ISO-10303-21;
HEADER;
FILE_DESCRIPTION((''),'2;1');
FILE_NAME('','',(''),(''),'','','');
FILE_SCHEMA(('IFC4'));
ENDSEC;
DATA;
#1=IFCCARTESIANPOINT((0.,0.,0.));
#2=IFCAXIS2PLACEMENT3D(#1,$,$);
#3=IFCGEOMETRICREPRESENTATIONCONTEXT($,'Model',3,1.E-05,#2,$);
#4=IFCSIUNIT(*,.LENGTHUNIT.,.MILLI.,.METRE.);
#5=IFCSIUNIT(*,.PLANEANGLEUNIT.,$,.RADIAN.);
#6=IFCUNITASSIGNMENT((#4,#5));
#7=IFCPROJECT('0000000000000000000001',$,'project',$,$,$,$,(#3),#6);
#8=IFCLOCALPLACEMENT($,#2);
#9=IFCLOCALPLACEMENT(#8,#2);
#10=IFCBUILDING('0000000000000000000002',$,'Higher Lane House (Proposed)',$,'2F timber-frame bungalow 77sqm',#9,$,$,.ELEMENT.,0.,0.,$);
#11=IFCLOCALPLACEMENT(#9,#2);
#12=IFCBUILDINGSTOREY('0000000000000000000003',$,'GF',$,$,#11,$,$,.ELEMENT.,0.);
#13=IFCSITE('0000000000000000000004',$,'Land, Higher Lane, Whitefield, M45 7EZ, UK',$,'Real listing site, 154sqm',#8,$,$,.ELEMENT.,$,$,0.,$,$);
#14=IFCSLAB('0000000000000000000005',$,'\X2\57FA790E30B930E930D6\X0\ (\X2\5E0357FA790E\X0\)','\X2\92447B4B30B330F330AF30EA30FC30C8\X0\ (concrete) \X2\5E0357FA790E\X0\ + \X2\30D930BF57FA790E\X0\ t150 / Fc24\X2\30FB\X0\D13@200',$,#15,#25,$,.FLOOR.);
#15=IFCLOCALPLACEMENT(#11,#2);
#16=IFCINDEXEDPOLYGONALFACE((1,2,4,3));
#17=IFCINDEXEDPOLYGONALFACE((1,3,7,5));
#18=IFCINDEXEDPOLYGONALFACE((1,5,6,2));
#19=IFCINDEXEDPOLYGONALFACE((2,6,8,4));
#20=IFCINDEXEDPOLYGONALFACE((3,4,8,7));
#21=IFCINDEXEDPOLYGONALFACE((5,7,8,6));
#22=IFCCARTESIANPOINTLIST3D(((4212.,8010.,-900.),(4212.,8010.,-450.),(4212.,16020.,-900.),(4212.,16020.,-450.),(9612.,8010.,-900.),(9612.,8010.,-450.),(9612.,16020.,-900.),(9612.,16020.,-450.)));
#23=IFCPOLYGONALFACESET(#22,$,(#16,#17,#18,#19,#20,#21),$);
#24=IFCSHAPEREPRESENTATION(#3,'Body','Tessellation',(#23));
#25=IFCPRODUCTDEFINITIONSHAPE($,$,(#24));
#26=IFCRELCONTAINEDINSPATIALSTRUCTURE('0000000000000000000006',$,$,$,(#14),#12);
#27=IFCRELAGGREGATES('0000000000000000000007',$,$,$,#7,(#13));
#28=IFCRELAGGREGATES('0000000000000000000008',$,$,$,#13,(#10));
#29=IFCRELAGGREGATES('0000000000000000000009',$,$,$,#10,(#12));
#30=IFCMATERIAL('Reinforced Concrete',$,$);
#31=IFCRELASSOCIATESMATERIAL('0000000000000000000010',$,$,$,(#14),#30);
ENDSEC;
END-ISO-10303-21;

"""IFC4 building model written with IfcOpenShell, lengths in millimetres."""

from ifc_helpers import new_model, si_unit, frame, frame_2d, origin, place, context, project, spatial, rectangle, extrude, material, element, save


model = new_model("IFC4")

# Units and contexts
model_context = context("Model", 3, precision=1e-05, world=origin())
ifc_project = project(units=[si_unit("LENGTHUNIT", "METRE", prefix="MILLI"), si_unit("PLANEANGLEUNIT", "RADIAN")], contexts=[model_context])

# Site, building, storey
site_placement = place(None, origin())
site = spatial("IfcSite", under=ifc_project, at=site_placement, Name="Land, Higher Lane, Whitefield, M45 7EZ, UK", ObjectType="Real listing site, 154sqm", CompositionType="ELEMENT", RefElevation=0.0)
building_placement = place(site_placement, origin())
building = spatial("IfcBuilding", under=site, at=building_placement, Name="Higher Lane House (Proposed)", ObjectType="2F timber-frame bungalow 77sqm", CompositionType="ELEMENT", ElevationOfRefHeight=0.0, ElevationOfTerrain=0.0)
storey_placement = place(building_placement, origin())
storey = spatial("IfcBuildingStorey", under=building, at=storey_placement, Name="GF", CompositionType="ELEMENT", Elevation=0.0)

# Slab
ifc_material_1 = material(Name="Reinforced Concrete")
slab_1_placement = place(storey_placement, frame((2106.0, 4005.0, -450.0)))
element("IfcSlab", 1, at=slab_1_placement, inside=storey, material=ifc_material_1, Name="基礎スラブ (布基礎)", Description="鉄筋コンクリート (concrete) 布基礎 + ベタ基礎 t150 / Fc24・D13@200", PredefinedType="FLOOR", context=model_context, shape_type="SweptSolid", body=[
    extrude(rectangle(XDim=5400.0, YDim=8010.0, at=frame_2d((2700.0, 4005.0))), frame((2106.0, 4005.0, -450.0)), (0.0, 0.0, 1.0), 450.0),
])

save(model, "model.ifc")
